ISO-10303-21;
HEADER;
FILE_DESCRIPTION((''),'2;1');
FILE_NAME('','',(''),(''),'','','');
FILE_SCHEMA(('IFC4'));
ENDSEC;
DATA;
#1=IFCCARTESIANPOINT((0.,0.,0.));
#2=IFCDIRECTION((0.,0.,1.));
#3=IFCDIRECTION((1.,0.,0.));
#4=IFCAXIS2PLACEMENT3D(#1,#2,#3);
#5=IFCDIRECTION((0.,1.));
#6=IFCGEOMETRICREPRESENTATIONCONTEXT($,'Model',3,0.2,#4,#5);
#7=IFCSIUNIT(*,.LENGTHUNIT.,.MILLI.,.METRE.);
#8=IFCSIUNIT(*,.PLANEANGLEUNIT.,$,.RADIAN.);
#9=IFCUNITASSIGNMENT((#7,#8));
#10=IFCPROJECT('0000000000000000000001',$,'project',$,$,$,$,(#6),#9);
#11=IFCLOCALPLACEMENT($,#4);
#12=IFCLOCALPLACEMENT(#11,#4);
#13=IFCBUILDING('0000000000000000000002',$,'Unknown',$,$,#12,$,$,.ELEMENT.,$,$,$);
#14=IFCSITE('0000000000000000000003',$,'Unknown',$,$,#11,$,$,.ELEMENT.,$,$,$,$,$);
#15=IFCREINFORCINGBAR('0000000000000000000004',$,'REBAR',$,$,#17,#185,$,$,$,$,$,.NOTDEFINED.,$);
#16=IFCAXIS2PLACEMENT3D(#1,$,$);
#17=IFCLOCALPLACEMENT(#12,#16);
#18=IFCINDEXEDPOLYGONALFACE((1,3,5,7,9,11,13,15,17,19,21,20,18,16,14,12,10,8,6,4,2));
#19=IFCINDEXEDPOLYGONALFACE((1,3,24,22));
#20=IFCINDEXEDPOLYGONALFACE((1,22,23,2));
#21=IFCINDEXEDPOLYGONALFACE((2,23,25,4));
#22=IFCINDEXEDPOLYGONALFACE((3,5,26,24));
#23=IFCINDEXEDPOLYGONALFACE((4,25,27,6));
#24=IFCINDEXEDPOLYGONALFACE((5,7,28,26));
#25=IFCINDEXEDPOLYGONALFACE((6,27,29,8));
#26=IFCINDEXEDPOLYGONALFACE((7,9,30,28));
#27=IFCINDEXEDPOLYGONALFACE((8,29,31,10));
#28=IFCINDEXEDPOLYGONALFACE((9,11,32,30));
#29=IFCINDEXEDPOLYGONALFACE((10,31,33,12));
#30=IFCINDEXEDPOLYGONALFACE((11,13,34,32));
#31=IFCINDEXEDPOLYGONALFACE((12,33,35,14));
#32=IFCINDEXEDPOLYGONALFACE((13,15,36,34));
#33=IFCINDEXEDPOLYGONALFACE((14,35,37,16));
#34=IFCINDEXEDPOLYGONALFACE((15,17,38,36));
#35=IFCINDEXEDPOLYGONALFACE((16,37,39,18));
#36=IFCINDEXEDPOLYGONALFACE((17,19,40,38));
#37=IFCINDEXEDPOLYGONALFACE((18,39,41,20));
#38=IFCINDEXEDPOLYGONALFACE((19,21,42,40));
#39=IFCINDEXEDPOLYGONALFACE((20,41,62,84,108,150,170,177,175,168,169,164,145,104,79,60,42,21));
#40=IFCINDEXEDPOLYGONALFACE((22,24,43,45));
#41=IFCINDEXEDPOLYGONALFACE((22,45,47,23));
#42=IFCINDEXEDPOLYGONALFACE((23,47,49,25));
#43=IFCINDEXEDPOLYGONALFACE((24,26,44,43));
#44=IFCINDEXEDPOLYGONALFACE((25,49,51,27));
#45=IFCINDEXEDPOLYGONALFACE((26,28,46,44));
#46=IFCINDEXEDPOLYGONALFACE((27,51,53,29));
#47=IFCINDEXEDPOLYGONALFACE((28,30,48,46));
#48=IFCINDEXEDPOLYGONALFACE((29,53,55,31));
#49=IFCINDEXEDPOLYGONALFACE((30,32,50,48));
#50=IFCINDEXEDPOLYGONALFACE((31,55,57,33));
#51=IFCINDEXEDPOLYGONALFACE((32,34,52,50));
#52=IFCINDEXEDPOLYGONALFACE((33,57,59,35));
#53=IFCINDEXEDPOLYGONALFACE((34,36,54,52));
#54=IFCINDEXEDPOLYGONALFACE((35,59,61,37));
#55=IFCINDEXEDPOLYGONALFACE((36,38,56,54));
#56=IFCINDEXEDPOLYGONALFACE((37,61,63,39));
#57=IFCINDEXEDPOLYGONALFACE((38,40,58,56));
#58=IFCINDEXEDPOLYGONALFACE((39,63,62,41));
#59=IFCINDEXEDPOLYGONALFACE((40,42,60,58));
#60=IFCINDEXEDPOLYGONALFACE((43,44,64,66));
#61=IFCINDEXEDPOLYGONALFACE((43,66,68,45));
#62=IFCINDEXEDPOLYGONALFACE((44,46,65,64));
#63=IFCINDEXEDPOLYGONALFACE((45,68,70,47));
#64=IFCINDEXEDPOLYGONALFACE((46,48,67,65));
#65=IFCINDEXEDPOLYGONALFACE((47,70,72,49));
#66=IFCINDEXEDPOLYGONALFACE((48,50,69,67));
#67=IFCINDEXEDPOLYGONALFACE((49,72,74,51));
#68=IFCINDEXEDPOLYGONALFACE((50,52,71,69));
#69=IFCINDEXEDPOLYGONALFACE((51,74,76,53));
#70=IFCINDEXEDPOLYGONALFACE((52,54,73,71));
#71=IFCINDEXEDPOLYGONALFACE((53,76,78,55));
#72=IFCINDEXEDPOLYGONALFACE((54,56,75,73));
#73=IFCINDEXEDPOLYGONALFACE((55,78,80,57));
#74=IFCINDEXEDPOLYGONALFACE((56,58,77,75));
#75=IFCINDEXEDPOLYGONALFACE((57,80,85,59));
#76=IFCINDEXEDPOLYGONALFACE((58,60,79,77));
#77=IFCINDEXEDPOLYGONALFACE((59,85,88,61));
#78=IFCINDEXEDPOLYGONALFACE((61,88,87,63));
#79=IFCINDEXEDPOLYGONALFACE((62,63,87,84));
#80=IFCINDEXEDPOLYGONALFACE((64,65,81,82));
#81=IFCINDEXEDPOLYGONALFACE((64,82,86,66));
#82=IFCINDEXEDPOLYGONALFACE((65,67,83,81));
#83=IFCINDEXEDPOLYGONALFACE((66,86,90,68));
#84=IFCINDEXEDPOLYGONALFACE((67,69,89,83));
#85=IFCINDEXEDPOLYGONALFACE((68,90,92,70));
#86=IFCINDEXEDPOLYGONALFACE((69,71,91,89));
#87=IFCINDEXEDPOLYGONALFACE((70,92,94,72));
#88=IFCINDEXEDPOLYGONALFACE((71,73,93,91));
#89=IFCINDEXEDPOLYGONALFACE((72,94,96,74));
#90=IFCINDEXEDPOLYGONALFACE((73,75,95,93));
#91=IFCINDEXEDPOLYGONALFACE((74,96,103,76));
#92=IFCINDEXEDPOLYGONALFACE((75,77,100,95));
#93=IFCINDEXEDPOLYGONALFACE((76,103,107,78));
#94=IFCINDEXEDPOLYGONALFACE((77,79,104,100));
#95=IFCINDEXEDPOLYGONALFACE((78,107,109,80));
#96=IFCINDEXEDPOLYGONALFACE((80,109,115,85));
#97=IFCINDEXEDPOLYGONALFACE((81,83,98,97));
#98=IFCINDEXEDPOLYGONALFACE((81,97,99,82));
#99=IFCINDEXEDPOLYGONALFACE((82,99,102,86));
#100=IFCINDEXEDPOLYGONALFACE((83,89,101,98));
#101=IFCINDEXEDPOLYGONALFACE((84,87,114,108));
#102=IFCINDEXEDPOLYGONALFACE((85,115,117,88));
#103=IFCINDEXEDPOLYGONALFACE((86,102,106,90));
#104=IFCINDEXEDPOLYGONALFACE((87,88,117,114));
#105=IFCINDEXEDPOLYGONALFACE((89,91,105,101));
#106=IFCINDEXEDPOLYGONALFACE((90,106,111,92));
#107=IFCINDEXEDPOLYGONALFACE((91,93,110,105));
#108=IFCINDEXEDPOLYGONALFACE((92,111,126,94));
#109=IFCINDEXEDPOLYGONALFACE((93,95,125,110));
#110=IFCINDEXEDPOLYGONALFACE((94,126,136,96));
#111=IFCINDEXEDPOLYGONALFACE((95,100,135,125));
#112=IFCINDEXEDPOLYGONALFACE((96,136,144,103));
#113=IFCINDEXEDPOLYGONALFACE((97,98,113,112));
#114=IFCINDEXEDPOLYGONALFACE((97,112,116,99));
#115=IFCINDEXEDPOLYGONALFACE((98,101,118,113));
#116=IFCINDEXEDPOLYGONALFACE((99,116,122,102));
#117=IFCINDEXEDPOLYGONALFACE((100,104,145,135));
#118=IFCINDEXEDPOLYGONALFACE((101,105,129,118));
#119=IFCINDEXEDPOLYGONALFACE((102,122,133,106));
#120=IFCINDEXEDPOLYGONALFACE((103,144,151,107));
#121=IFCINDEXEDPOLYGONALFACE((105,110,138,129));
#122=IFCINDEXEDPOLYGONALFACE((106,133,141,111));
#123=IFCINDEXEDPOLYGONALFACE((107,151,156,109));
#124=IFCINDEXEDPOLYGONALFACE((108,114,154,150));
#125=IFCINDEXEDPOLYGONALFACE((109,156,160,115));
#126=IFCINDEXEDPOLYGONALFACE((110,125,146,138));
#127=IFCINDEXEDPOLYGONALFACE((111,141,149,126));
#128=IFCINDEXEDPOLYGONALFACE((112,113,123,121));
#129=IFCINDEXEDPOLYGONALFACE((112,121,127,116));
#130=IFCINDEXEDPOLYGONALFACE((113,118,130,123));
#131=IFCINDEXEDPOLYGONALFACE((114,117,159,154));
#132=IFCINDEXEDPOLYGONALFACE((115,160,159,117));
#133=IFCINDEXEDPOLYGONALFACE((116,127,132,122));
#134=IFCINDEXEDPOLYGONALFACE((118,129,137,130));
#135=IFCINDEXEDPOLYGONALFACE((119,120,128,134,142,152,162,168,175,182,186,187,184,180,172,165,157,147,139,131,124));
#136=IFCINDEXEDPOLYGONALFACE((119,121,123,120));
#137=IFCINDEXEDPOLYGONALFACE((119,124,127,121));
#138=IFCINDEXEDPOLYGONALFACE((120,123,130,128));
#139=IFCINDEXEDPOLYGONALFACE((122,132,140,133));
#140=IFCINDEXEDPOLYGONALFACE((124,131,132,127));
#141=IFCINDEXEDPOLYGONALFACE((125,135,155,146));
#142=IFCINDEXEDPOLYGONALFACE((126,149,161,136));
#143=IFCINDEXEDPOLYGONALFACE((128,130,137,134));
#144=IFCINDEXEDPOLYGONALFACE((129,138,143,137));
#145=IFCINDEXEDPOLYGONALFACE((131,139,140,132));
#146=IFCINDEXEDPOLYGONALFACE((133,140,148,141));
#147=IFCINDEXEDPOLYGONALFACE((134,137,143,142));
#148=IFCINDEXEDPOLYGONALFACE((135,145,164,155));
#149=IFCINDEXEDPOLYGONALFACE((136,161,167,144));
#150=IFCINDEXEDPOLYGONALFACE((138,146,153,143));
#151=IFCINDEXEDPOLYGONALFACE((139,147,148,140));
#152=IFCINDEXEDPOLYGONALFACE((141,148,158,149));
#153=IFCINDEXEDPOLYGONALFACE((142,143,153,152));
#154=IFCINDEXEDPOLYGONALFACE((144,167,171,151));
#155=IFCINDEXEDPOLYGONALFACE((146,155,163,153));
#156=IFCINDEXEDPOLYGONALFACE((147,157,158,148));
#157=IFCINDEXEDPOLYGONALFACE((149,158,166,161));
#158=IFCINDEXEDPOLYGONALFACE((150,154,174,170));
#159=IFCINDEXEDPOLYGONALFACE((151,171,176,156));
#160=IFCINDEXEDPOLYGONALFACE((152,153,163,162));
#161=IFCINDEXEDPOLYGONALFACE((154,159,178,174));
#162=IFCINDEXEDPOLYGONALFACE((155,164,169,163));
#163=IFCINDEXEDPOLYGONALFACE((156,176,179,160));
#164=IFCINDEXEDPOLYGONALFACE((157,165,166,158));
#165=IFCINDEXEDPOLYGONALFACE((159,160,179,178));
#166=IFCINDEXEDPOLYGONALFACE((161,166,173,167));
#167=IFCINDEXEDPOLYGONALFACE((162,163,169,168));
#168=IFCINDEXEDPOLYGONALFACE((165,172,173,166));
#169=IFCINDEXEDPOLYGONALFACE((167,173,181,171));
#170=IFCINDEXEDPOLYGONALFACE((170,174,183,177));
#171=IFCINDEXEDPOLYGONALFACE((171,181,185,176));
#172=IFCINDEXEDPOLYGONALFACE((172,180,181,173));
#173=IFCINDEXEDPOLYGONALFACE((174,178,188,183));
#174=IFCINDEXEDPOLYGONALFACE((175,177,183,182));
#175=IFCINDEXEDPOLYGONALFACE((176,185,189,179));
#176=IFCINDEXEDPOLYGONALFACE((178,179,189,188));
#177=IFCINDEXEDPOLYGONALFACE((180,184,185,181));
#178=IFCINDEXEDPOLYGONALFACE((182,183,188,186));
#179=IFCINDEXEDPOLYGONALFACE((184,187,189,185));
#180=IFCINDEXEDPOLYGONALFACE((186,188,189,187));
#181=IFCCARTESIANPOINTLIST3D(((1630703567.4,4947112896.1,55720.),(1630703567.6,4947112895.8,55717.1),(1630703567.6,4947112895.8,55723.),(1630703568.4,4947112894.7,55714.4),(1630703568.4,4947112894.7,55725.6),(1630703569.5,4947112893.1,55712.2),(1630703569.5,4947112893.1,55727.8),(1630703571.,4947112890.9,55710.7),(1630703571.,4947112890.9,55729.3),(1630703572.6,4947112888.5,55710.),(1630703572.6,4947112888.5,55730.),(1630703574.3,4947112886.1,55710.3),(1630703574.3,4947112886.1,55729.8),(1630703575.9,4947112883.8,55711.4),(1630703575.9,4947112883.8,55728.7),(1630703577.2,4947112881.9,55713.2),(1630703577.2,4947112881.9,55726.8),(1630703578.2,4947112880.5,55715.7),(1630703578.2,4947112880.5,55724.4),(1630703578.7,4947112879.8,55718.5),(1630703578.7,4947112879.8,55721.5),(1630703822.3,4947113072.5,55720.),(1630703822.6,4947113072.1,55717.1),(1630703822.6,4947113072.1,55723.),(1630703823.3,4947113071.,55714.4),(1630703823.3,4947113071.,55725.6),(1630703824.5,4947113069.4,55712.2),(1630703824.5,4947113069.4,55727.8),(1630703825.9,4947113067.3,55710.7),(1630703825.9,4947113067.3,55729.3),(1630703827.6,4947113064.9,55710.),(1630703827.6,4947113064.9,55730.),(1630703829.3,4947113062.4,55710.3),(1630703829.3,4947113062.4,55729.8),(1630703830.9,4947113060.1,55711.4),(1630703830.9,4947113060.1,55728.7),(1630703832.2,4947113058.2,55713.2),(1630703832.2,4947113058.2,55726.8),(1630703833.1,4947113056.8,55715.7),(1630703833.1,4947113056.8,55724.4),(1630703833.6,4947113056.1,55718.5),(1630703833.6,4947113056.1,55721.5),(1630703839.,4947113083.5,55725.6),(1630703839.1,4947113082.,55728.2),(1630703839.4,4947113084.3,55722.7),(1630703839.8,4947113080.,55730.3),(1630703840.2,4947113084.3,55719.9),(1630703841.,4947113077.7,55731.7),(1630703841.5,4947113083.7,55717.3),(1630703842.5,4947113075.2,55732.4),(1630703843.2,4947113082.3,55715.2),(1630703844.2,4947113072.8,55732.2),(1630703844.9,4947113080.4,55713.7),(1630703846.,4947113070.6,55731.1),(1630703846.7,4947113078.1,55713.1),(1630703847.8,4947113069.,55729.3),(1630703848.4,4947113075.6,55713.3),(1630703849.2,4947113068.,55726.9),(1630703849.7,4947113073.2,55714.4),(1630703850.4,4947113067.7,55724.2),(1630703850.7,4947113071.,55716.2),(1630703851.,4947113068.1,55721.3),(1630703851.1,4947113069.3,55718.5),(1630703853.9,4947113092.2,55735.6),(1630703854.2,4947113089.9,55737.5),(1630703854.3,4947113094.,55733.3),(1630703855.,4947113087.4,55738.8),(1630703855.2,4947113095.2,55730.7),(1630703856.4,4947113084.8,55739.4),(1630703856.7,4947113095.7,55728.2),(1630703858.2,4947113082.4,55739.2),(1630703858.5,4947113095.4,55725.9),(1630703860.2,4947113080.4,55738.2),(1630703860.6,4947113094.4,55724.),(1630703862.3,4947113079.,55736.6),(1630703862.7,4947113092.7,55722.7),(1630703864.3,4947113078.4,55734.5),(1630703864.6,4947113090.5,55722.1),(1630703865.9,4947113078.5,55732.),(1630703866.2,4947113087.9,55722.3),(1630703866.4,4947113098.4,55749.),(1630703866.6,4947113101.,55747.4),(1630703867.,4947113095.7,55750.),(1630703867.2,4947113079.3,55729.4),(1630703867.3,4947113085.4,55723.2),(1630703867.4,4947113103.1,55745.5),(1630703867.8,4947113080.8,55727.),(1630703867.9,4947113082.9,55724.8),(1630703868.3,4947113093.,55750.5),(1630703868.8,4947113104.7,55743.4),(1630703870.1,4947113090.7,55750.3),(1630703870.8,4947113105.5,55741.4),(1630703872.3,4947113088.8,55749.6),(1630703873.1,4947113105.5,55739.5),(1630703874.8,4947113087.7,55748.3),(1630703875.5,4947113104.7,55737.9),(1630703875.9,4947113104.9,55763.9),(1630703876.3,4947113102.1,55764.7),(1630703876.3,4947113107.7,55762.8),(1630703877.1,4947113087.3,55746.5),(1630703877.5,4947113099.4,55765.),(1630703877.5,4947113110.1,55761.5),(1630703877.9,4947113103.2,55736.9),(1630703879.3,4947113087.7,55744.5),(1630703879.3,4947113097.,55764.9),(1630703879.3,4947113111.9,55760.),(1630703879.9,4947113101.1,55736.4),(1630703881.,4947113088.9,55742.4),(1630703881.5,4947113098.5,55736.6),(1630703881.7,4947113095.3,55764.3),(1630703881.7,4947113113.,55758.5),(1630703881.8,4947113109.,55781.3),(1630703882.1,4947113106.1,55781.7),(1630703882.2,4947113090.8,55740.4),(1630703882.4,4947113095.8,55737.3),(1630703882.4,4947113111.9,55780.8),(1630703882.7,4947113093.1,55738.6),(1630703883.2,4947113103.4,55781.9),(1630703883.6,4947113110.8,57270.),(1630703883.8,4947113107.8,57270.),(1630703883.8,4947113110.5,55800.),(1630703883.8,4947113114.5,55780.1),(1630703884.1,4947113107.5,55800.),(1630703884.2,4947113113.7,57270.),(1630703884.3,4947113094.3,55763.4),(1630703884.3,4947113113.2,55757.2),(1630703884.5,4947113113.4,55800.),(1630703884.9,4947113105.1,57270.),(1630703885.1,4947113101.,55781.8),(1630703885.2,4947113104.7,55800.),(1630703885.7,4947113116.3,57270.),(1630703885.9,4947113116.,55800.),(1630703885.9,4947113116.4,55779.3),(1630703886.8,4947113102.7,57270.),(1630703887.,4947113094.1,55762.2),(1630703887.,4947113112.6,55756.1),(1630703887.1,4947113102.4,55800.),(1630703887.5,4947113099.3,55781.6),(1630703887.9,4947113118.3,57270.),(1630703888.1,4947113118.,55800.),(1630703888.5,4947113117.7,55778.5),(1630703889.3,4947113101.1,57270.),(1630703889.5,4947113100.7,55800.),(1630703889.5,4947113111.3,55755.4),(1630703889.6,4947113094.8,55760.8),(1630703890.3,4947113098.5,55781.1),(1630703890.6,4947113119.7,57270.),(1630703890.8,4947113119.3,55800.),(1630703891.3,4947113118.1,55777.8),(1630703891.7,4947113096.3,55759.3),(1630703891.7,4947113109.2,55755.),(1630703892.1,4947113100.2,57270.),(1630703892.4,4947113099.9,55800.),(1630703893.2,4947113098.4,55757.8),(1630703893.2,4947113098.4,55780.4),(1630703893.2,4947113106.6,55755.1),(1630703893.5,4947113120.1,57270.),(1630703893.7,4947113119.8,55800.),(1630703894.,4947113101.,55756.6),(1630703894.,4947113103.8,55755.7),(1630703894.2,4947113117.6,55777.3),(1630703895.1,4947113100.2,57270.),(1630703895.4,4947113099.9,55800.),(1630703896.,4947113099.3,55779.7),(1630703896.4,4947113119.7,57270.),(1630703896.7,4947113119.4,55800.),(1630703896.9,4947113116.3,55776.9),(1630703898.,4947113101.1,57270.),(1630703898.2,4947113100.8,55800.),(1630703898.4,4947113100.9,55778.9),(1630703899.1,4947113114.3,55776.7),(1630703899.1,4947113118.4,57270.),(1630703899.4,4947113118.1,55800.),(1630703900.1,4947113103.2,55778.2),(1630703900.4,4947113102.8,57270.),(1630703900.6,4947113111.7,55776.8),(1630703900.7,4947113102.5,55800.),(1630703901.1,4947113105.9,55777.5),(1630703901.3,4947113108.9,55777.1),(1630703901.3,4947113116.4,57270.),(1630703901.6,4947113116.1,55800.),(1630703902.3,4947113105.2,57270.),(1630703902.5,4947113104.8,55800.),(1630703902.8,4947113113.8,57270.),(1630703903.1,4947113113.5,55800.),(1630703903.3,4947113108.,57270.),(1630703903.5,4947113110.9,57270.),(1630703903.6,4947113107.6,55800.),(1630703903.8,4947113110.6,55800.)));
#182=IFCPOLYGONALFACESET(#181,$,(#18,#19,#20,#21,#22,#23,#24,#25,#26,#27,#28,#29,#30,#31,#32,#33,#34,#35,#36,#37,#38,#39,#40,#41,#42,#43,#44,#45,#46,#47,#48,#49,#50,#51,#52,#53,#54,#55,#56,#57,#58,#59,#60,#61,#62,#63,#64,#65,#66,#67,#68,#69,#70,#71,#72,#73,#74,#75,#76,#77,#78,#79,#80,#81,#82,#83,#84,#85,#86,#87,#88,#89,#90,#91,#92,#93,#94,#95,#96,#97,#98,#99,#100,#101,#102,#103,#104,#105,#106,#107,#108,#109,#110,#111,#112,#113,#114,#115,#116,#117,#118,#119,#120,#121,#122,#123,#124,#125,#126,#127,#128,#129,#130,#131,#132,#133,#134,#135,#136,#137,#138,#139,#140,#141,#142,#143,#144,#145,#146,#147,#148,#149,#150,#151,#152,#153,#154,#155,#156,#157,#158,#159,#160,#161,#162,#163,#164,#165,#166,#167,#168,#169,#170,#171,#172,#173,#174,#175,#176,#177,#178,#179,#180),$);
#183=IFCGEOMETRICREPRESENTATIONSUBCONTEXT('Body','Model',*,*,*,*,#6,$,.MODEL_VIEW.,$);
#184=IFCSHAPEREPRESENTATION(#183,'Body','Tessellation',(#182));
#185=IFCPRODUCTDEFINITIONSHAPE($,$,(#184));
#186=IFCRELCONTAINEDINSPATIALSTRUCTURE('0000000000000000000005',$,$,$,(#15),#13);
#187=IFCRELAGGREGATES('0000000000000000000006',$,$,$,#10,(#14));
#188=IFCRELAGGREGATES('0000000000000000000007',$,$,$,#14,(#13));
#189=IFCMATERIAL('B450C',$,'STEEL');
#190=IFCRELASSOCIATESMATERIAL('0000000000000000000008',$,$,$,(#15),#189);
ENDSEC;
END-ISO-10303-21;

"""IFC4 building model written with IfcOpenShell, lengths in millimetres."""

from ifc_helpers import new_model, entity, si_unit, direction, frame, origin_with_axes, place, context, subcontext, project, spatial, material, element, save


model = new_model("IFC4")

# Units and contexts
model_context = context("Model", 3, precision=0.2, world=origin_with_axes(), true_north=direction((0.0, 1.0)))
body_context = subcontext(model_context, "Body", "Model", "MODEL_VIEW")
ifc_project = project(units=[si_unit("LENGTHUNIT", "METRE", prefix="MILLI"), si_unit("PLANEANGLEUNIT", "RADIAN")], contexts=[model_context])

# Site, building
site_placement = place(None, origin_with_axes())
site = spatial("IfcSite", under=ifc_project, at=site_placement, Name="Unknown", CompositionType="ELEMENT")
building_placement = place(site_placement, origin_with_axes())
building = spatial("IfcBuilding", under=site, at=building_placement, Name="Unknown", CompositionType="ELEMENT")

# Reinforcing bar
ifc_material = material(Name="B450C", Category="STEEL")
reinforcing_bar_1_placement = place(building_placement, frame((1630703906.5, 4947113179.3, 55670.0), z_axis=(0.568806, -0.822472, 0.0), x_axis=(0.0, 0.0, 1.0)))
element("IfcReinforcingBar", 1, at=reinforcing_bar_1_placement, inside=building, material=ifc_material, Name="REBAR", PredefinedType="NOTDEFINED", context=body_context, shape_type="AdvancedSweptSolid", body=[
    entity("IfcSweptDiskSolid", entity("IfcIndexedPolyCurve", entity("IfcCartesianPointList3D", [[50.0, 440.0, 50.0], [50.0, 130.0, 50.0], [73.4, 73.4, 50.0], [130.0, 50.0, 50.0], [1600.0, 50.0, 49.5]]), [entity("IfcLineIndex", [1, 2]), entity("IfcArcIndex", [2, 3, 4]), entity("IfcLineIndex", [4, 5])]), 10.0),
])

save(model, "model.ifc")
